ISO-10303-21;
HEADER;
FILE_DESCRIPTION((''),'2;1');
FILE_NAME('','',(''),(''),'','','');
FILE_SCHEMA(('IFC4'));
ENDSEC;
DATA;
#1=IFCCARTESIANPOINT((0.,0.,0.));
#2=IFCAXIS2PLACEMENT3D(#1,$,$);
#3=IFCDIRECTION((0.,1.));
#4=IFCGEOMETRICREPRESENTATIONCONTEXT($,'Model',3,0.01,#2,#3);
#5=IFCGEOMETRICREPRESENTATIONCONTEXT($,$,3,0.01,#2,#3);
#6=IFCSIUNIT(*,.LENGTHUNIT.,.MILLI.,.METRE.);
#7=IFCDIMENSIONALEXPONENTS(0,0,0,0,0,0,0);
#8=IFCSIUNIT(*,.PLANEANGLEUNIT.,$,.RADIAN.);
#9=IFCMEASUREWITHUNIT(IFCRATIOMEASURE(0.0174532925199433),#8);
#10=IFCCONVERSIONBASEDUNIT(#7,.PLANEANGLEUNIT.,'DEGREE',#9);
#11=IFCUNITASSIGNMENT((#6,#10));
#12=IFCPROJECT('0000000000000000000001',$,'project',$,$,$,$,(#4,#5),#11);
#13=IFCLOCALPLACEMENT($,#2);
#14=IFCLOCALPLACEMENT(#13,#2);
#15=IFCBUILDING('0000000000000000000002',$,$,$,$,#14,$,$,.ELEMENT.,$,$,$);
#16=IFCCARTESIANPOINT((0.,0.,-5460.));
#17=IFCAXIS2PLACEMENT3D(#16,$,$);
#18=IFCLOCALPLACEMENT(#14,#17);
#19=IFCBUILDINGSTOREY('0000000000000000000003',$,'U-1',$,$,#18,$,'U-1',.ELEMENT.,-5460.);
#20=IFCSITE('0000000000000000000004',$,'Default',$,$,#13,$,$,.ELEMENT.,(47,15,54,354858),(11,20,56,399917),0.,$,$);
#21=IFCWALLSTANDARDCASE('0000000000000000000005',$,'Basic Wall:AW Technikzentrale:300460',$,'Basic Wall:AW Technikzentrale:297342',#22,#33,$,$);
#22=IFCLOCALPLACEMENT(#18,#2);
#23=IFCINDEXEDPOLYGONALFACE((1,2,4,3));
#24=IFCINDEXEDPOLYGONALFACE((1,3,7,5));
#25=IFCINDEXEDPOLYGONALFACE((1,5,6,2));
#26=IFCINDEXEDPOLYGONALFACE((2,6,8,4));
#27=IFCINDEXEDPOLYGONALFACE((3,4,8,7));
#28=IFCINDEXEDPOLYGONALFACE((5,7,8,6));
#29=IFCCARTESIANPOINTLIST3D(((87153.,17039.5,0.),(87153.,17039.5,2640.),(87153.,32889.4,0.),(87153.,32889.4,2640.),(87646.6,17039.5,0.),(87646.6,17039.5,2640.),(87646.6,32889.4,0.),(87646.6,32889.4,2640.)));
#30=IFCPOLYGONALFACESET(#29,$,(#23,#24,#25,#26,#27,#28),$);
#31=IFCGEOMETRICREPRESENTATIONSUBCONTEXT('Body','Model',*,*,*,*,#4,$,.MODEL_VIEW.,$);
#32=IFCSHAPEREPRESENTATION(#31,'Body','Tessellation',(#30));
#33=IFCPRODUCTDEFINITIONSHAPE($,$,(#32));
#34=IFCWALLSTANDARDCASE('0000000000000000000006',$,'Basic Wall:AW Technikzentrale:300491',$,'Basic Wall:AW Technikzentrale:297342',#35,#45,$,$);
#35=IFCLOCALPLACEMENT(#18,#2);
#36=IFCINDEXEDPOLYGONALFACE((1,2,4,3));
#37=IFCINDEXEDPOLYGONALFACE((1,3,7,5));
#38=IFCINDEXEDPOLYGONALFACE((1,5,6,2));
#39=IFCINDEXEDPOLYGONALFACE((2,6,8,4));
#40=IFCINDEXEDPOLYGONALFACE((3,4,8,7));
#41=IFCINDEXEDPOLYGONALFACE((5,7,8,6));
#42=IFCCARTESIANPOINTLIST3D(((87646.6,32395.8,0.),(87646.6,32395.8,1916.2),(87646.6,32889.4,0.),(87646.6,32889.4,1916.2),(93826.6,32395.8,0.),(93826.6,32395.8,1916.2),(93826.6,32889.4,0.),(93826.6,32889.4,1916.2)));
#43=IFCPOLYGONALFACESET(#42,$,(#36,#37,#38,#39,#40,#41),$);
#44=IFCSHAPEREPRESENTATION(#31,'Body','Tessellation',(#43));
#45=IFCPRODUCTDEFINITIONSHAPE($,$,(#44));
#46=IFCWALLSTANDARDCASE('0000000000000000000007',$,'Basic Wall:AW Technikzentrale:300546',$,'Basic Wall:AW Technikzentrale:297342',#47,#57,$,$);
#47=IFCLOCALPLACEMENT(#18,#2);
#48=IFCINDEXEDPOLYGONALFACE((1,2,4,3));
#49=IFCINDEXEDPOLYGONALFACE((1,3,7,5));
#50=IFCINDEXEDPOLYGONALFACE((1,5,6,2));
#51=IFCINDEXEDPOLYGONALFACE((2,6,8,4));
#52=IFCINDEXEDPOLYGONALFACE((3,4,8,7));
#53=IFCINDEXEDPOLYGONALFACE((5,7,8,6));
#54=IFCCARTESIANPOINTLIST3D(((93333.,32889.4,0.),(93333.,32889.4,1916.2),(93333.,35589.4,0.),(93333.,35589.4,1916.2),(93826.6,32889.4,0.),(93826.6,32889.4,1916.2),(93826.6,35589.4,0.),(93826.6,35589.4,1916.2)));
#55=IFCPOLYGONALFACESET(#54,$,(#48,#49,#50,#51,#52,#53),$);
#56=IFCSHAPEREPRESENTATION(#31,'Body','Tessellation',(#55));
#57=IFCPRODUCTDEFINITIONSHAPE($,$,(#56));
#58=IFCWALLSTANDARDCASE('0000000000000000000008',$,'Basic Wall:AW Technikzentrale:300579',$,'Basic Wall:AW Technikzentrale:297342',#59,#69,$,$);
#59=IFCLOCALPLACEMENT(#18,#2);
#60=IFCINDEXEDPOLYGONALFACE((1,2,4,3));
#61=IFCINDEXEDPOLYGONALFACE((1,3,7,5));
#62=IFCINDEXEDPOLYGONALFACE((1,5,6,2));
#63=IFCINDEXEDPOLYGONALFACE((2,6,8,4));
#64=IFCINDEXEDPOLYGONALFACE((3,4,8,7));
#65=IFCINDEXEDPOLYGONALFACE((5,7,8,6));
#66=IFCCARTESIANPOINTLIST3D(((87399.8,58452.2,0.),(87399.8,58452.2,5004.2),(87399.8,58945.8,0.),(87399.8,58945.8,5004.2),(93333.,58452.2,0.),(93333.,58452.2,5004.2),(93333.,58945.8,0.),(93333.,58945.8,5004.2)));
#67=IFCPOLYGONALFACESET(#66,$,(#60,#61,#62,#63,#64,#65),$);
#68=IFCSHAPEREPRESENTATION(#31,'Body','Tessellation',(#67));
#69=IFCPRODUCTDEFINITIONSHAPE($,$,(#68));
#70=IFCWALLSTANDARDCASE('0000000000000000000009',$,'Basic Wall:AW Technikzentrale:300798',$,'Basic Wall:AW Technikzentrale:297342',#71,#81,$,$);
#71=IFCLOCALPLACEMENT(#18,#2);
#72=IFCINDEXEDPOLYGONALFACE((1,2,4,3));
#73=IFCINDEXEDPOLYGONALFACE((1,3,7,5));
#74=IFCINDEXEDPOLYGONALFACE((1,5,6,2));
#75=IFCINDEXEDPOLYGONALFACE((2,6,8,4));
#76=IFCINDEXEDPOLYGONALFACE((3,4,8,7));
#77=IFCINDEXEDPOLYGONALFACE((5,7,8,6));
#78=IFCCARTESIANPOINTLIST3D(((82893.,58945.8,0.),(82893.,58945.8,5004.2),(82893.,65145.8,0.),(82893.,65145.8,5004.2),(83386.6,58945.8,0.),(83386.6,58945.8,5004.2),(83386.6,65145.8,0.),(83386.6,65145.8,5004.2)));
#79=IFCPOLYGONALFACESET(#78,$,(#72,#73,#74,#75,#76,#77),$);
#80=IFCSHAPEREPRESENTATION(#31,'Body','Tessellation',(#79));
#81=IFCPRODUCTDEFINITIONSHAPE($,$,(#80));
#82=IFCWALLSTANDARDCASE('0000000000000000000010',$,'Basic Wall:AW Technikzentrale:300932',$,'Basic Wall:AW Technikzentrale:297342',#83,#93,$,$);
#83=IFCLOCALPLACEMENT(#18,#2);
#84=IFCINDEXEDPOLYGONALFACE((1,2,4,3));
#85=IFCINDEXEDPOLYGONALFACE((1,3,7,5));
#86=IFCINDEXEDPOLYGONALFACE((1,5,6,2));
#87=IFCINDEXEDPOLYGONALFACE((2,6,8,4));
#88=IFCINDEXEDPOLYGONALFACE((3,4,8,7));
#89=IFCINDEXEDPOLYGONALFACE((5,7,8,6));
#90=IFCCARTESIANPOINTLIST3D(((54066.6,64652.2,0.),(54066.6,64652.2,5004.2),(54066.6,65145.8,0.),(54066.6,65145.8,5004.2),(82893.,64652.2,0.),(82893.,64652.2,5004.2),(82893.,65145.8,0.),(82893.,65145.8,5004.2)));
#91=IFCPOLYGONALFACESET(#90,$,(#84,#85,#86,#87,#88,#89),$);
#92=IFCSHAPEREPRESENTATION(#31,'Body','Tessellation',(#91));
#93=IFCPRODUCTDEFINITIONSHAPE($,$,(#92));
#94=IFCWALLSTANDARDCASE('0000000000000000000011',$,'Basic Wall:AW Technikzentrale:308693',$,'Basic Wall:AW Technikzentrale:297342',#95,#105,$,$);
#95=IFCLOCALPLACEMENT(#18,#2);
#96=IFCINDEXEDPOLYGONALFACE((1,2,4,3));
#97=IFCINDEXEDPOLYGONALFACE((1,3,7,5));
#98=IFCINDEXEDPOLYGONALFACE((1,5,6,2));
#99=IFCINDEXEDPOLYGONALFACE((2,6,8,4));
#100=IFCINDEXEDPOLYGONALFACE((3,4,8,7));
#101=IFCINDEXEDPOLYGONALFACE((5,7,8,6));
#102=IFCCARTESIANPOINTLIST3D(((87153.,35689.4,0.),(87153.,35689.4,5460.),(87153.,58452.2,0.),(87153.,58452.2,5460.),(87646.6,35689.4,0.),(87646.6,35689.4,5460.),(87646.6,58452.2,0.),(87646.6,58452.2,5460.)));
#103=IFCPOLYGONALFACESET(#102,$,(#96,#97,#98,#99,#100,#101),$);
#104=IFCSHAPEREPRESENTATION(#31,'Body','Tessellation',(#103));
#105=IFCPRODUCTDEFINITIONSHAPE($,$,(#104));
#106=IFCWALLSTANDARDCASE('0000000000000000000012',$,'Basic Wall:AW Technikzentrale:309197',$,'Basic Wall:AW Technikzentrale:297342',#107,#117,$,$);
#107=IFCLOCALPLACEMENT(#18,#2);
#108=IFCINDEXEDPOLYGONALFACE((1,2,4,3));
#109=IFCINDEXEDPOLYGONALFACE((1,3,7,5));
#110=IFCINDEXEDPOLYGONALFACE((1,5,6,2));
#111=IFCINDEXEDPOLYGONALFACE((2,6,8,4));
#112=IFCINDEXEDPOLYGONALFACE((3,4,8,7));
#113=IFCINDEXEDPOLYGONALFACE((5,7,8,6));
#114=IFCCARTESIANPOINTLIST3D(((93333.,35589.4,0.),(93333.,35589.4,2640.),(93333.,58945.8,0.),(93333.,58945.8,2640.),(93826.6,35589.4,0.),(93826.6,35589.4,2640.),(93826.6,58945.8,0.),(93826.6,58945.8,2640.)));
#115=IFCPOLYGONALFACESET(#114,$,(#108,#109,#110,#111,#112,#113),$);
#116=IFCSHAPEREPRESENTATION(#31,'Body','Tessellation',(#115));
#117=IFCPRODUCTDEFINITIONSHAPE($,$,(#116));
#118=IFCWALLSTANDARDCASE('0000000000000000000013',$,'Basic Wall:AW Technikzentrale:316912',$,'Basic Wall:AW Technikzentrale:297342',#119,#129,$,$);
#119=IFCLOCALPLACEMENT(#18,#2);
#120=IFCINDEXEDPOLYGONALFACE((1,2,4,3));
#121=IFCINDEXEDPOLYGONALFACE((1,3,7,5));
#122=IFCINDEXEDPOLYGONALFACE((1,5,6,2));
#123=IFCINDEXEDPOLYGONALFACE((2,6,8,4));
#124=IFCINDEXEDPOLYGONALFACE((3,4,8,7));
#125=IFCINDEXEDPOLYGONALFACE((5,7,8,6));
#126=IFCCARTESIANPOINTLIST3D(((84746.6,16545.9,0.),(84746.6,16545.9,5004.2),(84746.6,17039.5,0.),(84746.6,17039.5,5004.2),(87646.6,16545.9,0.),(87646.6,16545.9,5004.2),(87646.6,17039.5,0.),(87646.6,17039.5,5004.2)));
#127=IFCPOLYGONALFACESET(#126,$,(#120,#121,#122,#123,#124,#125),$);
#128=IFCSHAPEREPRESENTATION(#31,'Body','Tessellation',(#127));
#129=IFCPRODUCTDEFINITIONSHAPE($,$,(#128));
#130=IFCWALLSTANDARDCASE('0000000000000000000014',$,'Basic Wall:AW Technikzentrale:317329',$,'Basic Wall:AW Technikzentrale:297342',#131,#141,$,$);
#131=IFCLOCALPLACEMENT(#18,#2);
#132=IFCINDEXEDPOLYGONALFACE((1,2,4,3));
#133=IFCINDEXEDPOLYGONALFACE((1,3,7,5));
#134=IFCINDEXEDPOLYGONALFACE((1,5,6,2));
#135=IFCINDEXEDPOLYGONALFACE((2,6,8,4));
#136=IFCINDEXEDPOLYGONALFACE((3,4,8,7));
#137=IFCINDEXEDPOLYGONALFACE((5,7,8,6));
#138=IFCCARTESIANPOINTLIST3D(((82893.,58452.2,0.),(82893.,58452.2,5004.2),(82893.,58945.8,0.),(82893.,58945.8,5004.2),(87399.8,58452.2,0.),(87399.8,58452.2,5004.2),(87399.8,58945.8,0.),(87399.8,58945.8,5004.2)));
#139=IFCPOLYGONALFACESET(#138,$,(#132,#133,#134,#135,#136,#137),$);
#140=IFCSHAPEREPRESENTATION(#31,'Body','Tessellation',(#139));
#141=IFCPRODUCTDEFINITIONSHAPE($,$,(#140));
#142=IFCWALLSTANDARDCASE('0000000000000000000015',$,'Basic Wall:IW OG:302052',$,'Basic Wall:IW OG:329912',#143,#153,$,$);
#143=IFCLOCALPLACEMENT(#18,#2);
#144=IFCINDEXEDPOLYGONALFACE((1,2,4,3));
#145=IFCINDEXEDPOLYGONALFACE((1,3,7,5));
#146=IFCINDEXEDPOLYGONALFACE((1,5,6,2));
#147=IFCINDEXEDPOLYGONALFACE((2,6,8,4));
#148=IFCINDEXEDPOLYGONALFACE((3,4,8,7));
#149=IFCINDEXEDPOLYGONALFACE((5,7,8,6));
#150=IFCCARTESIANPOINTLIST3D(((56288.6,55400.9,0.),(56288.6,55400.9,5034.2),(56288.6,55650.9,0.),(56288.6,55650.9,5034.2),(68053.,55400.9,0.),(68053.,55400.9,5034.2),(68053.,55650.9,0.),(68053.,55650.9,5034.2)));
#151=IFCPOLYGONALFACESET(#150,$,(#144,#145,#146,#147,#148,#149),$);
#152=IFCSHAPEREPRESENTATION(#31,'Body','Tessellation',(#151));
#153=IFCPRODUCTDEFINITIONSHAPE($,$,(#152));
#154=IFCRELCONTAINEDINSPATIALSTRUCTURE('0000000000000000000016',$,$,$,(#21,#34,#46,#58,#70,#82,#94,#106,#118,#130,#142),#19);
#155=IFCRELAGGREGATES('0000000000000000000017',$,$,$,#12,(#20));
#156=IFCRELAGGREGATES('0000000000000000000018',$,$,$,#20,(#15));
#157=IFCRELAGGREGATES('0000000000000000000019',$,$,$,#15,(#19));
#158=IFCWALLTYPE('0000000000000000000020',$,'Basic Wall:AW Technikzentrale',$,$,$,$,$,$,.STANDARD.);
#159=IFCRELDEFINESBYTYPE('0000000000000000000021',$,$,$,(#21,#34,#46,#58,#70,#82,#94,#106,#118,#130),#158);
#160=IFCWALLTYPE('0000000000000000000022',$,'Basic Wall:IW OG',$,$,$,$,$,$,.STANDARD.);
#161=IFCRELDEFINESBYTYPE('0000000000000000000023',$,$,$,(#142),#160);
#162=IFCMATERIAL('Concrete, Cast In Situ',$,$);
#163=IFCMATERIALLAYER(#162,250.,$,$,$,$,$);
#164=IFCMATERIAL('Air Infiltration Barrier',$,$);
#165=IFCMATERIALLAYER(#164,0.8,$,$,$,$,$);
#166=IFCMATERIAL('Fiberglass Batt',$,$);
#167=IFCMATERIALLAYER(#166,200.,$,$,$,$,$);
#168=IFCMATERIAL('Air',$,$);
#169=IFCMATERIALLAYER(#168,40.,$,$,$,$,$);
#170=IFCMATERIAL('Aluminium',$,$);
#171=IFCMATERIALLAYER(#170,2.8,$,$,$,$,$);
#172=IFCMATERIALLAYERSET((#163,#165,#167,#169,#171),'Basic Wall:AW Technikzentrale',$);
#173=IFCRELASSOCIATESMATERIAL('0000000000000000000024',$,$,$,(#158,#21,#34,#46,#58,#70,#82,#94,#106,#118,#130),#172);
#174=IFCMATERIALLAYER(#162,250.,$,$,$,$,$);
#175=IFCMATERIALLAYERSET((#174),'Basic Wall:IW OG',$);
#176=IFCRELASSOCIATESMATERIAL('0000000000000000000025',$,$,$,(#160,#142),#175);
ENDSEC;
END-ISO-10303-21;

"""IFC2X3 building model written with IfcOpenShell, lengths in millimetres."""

from ifc_helpers import new_model, entity, si_unit, converted_unit, direction, frame, frame_2d, origin, place, context, subcontext, project, spatial, polyline, rectangle, extrude, clip, bounded_halfspace, material, layer, layer_set, layer_usage, type_object, element, save


model = new_model("IFC2X3")

# Units and contexts
model_context = context("Model", 3, precision=0.01, world=origin(), true_north=direction((0.0, 1.0)))
context_of_model = context(None, 3, precision=0.01, world=origin(), true_north=direction((0.0, 1.0)))
body_context = subcontext(model_context, "Body", "Model", "MODEL_VIEW")
ifc_project = project(units=[si_unit("LENGTHUNIT", "METRE", prefix="MILLI"), converted_unit("PLANEANGLEUNIT", "DEGREE", entity("IfcRatioMeasure", 0.0174532925199433), si_unit("PLANEANGLEUNIT", "RADIAN"), dimensions=[0, 0, 0, 0, 0, 0, 0])], contexts=[model_context, context_of_model])

# Site, building, storey
site_placement = place(None, origin())
site = spatial("IfcSite", under=ifc_project, at=site_placement, Name="Default", CompositionType="ELEMENT", RefLatitude=(47, 15, 54, 354858), RefLongitude=(11, 20, 56, 399917), RefElevation=0.0)
building_placement = place(site_placement, origin())
building = spatial("IfcBuilding", under=site, at=building_placement, CompositionType="ELEMENT")
storey_placement = place(building_placement, frame((0.0, 0.0, -5460.0)))
storey = spatial("IfcBuildingStorey", under=building, at=storey_placement, Name="U-1", LongName="U-1", CompositionType="ELEMENT", Elevation=-5460.0)

# Walls
ifc_material_1 = material(Name="Concrete, Cast In Situ")
ifc_layer_1 = layer(ifc_material_1, 250.0)
ifc_material_2 = material(Name="Air Infiltration Barrier")
ifc_layer_2 = layer(ifc_material_2, 0.8)
ifc_material_3 = material(Name="Fiberglass Batt")
ifc_layer_3 = layer(ifc_material_3, 200.0)
ifc_material_4 = material(Name="Air")
ifc_layer_4 = layer(ifc_material_4, 40.0)
ifc_material_5 = material(Name="Aluminium")
ifc_layer_5 = layer(ifc_material_5, 2.8)
ifc_layer_set_1 = layer_set([ifc_layer_1, ifc_layer_2, ifc_layer_3, ifc_layer_4, ifc_layer_5], Name="Basic Wall:AW Technikzentrale")
ifc_layer_usage_1 = layer_usage(ifc_layer_set_1, "AXIS2", "NEGATIVE", 246.8)
wall_type_1 = type_object("IfcWallType", Name="Basic Wall:AW Technikzentrale", PredefinedType="STANDARD", material=ifc_layer_set_1)
wall_1_placement = place(storey_placement, frame((87399.8, 17039.5, 0.0), z_axis=(0.0, 0.0, 1.0), x_axis=(0.0, 1.0, 0.0)))
element("IfcWallStandardCase", 1, at=wall_1_placement, inside=storey, type_object=wall_type_1, material=ifc_layer_usage_1, Name="Basic Wall:AW Technikzentrale:300460", ObjectType="Basic Wall:AW Technikzentrale:297342", context=body_context, shape_type="SweptSolid", body=[
    extrude(rectangle(XDim=15850.0, YDim=493.6, at=frame_2d((7925.0, 0.0), x_axis=(-1.0, 0.0))), origin(), (0.0, 0.0, 1.0), 2640.0),
])
ifc_layer_usage_2 = layer_usage(ifc_layer_set_1, "AXIS2", "NEGATIVE", 246.8)
wall_2_placement = place(storey_placement, frame((87646.6, 32642.6, 0.0)))
element("IfcWallStandardCase", 2, at=wall_2_placement, inside=storey, type_object=wall_type_1, material=ifc_layer_usage_2, Name="Basic Wall:AW Technikzentrale:300491", ObjectType="Basic Wall:AW Technikzentrale:297342", context=body_context, shape_type="Clipping", body=[
    clip(extrude(rectangle(XDim=6180.0, YDim=493.6, at=frame_2d((3090.0, 0.0), x_axis=(-1.0, 0.0))), origin(), (0.0, 0.0, 1.0), 1916.2), bounded_halfspace(frame((0.0, -246.8, 1916.2), z_axis=(0.0, 0.0, -1.0), x_axis=(-1.0, 0.0, 0.0)), True, frame((0.0, -246.8, 1916.2)), polyline([(0.0, 0.0), (6180.0, 0.0), (6180.0, 493.6), (5686.4, 493.6), (0.0, 493.6), (0.0, 0.0)]))),
])
ifc_layer_usage_3 = layer_usage(ifc_layer_set_1, "AXIS2", "NEGATIVE", 246.8)
wall_3_placement = place(storey_placement, frame((93579.8, 32889.4, 0.0), z_axis=(0.0, 0.0, 1.0), x_axis=(0.0, 1.0, 0.0)))
element("IfcWallStandardCase", 3, at=wall_3_placement, inside=storey, type_object=wall_type_1, material=ifc_layer_usage_3, Name="Basic Wall:AW Technikzentrale:300546", ObjectType="Basic Wall:AW Technikzentrale:297342", context=body_context, shape_type="Clipping", body=[
    clip(extrude(rectangle(XDim=2700.0, YDim=493.6, at=frame_2d((1350.0, 0.0), x_axis=(-1.0, 0.0))), origin(), (0.0, 0.0, 1.0), 1916.2), bounded_halfspace(frame((0.0, -246.8, 1916.2), z_axis=(0.0, 0.0, -1.0), x_axis=(0.0, 1.0, 0.0)), True, frame((0.0, -246.8, 1916.2)), polyline([(0.0, 0.0), (2600.0, 0.0), (2600.0, 493.6), (0.0, 493.6), (0.0, 0.0)]))),
])
ifc_layer_usage_4 = layer_usage(ifc_layer_set_1, "AXIS2", "NEGATIVE", 246.8)
wall_4_placement = place(storey_placement, frame((93579.8, 58699.0, 0.0), z_axis=(0.0, 0.0, 1.0), x_axis=(-1.0, 0.0, 0.0)))
element("IfcWallStandardCase", 4, at=wall_4_placement, inside=storey, type_object=wall_type_1, material=ifc_layer_usage_4, Name="Basic Wall:AW Technikzentrale:300579", ObjectType="Basic Wall:AW Technikzentrale:297342", context=body_context, shape_type="Clipping", body=[
    clip(extrude(rectangle(XDim=5933.2, YDim=493.6, at=frame_2d((3213.4, 0.0), x_axis=(-1.0, 0.0))), origin(), (0.0, 0.0, 1.0), 5004.2), bounded_halfspace(frame((0.0, -246.8, 5004.2), z_axis=(0.0, 0.0, -1.0), x_axis=(0.0, -1.0, 0.0)), True, frame((0.0, -246.8, 5004.2)), polyline([(0.0, 0.0), (5933.2, 0.0), (5933.2, 493.6), (0.0, 493.6), (0.0, 0.0)]))),
])
ifc_layer_usage_5 = layer_usage(ifc_layer_set_1, "AXIS2", "NEGATIVE", 246.8)
wall_5_placement = place(storey_placement, frame((83139.8, 58945.8, 0.0), z_axis=(0.0, 0.0, 1.0), x_axis=(0.0, 1.0, 0.0)))
element("IfcWallStandardCase", 5, at=wall_5_placement, inside=storey, type_object=wall_type_1, material=ifc_layer_usage_5, Name="Basic Wall:AW Technikzentrale:300798", ObjectType="Basic Wall:AW Technikzentrale:297342", context=body_context, shape_type="Clipping", body=[
    clip(extrude(rectangle(XDim=6200.0, YDim=493.6, at=frame_2d((3100.0, 0.0), x_axis=(-1.0, 0.0))), origin(), (0.0, 0.0, 1.0), 5004.2), bounded_halfspace(frame((0.0, -246.8, 5004.2), z_axis=(0.0, 0.0, -1.0), x_axis=(-1.0, 0.0, 0.0)), True, frame((0.0, -246.8, 5004.2)), polyline([(0.0, 0.0), (6200.0, 0.0), (6200.0, 493.6), (5706.4, 493.6), (0.0, 493.6), (0.0, 0.0)]))),
])
ifc_layer_usage_6 = layer_usage(ifc_layer_set_1, "AXIS2", "NEGATIVE", 246.8)
wall_6_placement = place(storey_placement, frame((82893.0, 64899.0, 0.0), z_axis=(0.0, 0.0, 1.0), x_axis=(-1.0, 0.0, 0.0)))
element("IfcWallStandardCase", 6, at=wall_6_placement, inside=storey, type_object=wall_type_1, material=ifc_layer_usage_6, Name="Basic Wall:AW Technikzentrale:300932", ObjectType="Basic Wall:AW Technikzentrale:297342", context=body_context, shape_type="Clipping", body=[
    clip(extrude(rectangle(XDim=28826.4, YDim=493.6, at=frame_2d((14413.2, 0.0), x_axis=(-1.0, 0.0))), origin(), (0.0, 0.0, 1.0), 5004.2), bounded_halfspace(frame((0.0, -246.8, 5004.2), z_axis=(0.0, 0.0, -1.0), x_axis=(0.0, 1.0, 0.0)), True, frame((0.0, -246.8, 5004.2)), polyline([(0.0, 0.0), (28826.4, 0.0), (28826.4, 493.6), (0.0, 493.6), (0.0, 0.0)]))),
])
ifc_layer_usage_7 = layer_usage(ifc_layer_set_1, "AXIS2", "POSITIVE", -246.8)
wall_7_placement = place(storey_placement, frame((87399.8, 58452.2, 0.0), z_axis=(0.0, 0.0, 1.0), x_axis=(0.0, -1.0, 0.0)))
element("IfcWallStandardCase", 7, at=wall_7_placement, inside=storey, type_object=wall_type_1, material=ifc_layer_usage_7, Name="Basic Wall:AW Technikzentrale:308693", ObjectType="Basic Wall:AW Technikzentrale:297342", context=body_context, shape_type="SweptSolid", body=[
    extrude(rectangle(XDim=22762.8, YDim=493.6, at=frame_2d((11381.4, 0.0), x_axis=(-1.0, 0.0))), origin(), (0.0, 0.0, 1.0), 5460.0),
])
ifc_layer_usage_8 = layer_usage(ifc_layer_set_1, "AXIS2", "NEGATIVE", 246.8)
wall_8_placement = place(storey_placement, frame((93579.8, 35589.4, 0.0), z_axis=(0.0, 0.0, 1.0), x_axis=(0.0, 1.0, 0.0)))
element("IfcWallStandardCase", 8, at=wall_8_placement, inside=storey, type_object=wall_type_1, material=ifc_layer_usage_8, Name="Basic Wall:AW Technikzentrale:309197", ObjectType="Basic Wall:AW Technikzentrale:297342", context=body_context, shape_type="SweptSolid", body=[
    extrude(rectangle(XDim=23356.4, YDim=493.6, at=frame_2d((11678.2, 0.0), x_axis=(-1.0, 0.0))), origin(), (0.0, 0.0, 1.0), 2640.0),
])
ifc_layer_usage_9 = layer_usage(ifc_layer_set_1, "AXIS2", "NEGATIVE", 246.8)
wall_9_placement = place(storey_placement, frame((84746.6, 16792.7, 0.0)))
element("IfcWallStandardCase", 9, at=wall_9_placement, inside=storey, type_object=wall_type_1, material=ifc_layer_usage_9, Name="Basic Wall:AW Technikzentrale:316912", ObjectType="Basic Wall:AW Technikzentrale:297342", context=body_context, shape_type="Clipping", body=[
    clip(extrude(rectangle(XDim=2900.0, YDim=493.6, at=frame_2d((1450.0, 0.0), x_axis=(-1.0, 0.0))), origin(), (0.0, 0.0, 1.0), 5004.2), bounded_halfspace(frame((0.0, -246.8, 5004.2), z_axis=(0.0, 0.0, -1.0), x_axis=(0.0, 1.0, 0.0)), True, frame((0.0, -246.8, 5004.2)), polyline([(0.0, 0.0), (2900.0, 0.0), (2900.0, 493.6), (2406.4, 493.6), (0.0, 493.6), (0.0, 0.0)]))),
])
ifc_layer_usage_10 = layer_usage(ifc_layer_set_1, "AXIS2", "NEGATIVE", 246.8)
wall_10_placement = place(storey_placement, frame((87399.8, 58699.0, 0.0), z_axis=(0.0, 0.0, 1.0), x_axis=(-1.0, 0.0, 0.0)))
element("IfcWallStandardCase", 10, at=wall_10_placement, inside=storey, type_object=wall_type_1, material=ifc_layer_usage_10, Name="Basic Wall:AW Technikzentrale:317329", ObjectType="Basic Wall:AW Technikzentrale:297342", context=body_context, shape_type="Clipping", body=[
    clip(extrude(rectangle(XDim=4506.8, YDim=493.6, at=frame_2d((2253.4, 0.0), x_axis=(-1.0, 0.0))), origin(), (0.0, 0.0, 1.0), 5004.2), bounded_halfspace(frame((4013.2, -246.8, 5004.2), z_axis=(0.0, 0.0, -1.0), x_axis=(0.0, 1.0, 0.0)), True, frame((4013.2, -246.8, 5004.2)), polyline([(0.0, 0.0), (493.6, 0.0), (493.6, 493.6), (0.0, 493.6), (0.0, 0.0)]))),
])
ifc_layer_6 = layer(ifc_material_1, 250.0)
ifc_layer_set_2 = layer_set([ifc_layer_6], Name="Basic Wall:IW OG")
ifc_layer_usage_11 = layer_usage(ifc_layer_set_2, "AXIS2", "NEGATIVE", 125.0)
wall_type_2 = type_object("IfcWallType", Name="Basic Wall:IW OG", PredefinedType="STANDARD", material=ifc_layer_set_2)
wall_11_placement = place(storey_placement, frame((68053.0, 55525.9, 0.0), z_axis=(0.0, 0.0, 1.0), x_axis=(-1.0, 0.0, 0.0)))
element("IfcWallStandardCase", 11, at=wall_11_placement, inside=storey, type_object=wall_type_2, material=ifc_layer_usage_11, Name="Basic Wall:IW OG:302052", ObjectType="Basic Wall:IW OG:329912", context=body_context, shape_type="Clipping", body=[
    clip(extrude(rectangle(XDim=11764.4, YDim=250.0, at=frame_2d((5882.2, 0.0), x_axis=(-1.0, 0.0))), origin(), (0.0, 0.0, 1.0), 5034.2), bounded_halfspace(frame((0.0, -125.0, 5034.2), z_axis=(0.0, 0.0, -1.0), x_axis=(-1.0, 0.0, 0.0)), True, frame((0.0, -125.0, 5034.2)), polyline([(0.0, 0.0), (11764.4, 0.0), (11764.4, 250.0), (11564.4, 250.0), (0.0, 250.0), (0.0, 0.0)]))),
])

save(model, "model.ifc")
